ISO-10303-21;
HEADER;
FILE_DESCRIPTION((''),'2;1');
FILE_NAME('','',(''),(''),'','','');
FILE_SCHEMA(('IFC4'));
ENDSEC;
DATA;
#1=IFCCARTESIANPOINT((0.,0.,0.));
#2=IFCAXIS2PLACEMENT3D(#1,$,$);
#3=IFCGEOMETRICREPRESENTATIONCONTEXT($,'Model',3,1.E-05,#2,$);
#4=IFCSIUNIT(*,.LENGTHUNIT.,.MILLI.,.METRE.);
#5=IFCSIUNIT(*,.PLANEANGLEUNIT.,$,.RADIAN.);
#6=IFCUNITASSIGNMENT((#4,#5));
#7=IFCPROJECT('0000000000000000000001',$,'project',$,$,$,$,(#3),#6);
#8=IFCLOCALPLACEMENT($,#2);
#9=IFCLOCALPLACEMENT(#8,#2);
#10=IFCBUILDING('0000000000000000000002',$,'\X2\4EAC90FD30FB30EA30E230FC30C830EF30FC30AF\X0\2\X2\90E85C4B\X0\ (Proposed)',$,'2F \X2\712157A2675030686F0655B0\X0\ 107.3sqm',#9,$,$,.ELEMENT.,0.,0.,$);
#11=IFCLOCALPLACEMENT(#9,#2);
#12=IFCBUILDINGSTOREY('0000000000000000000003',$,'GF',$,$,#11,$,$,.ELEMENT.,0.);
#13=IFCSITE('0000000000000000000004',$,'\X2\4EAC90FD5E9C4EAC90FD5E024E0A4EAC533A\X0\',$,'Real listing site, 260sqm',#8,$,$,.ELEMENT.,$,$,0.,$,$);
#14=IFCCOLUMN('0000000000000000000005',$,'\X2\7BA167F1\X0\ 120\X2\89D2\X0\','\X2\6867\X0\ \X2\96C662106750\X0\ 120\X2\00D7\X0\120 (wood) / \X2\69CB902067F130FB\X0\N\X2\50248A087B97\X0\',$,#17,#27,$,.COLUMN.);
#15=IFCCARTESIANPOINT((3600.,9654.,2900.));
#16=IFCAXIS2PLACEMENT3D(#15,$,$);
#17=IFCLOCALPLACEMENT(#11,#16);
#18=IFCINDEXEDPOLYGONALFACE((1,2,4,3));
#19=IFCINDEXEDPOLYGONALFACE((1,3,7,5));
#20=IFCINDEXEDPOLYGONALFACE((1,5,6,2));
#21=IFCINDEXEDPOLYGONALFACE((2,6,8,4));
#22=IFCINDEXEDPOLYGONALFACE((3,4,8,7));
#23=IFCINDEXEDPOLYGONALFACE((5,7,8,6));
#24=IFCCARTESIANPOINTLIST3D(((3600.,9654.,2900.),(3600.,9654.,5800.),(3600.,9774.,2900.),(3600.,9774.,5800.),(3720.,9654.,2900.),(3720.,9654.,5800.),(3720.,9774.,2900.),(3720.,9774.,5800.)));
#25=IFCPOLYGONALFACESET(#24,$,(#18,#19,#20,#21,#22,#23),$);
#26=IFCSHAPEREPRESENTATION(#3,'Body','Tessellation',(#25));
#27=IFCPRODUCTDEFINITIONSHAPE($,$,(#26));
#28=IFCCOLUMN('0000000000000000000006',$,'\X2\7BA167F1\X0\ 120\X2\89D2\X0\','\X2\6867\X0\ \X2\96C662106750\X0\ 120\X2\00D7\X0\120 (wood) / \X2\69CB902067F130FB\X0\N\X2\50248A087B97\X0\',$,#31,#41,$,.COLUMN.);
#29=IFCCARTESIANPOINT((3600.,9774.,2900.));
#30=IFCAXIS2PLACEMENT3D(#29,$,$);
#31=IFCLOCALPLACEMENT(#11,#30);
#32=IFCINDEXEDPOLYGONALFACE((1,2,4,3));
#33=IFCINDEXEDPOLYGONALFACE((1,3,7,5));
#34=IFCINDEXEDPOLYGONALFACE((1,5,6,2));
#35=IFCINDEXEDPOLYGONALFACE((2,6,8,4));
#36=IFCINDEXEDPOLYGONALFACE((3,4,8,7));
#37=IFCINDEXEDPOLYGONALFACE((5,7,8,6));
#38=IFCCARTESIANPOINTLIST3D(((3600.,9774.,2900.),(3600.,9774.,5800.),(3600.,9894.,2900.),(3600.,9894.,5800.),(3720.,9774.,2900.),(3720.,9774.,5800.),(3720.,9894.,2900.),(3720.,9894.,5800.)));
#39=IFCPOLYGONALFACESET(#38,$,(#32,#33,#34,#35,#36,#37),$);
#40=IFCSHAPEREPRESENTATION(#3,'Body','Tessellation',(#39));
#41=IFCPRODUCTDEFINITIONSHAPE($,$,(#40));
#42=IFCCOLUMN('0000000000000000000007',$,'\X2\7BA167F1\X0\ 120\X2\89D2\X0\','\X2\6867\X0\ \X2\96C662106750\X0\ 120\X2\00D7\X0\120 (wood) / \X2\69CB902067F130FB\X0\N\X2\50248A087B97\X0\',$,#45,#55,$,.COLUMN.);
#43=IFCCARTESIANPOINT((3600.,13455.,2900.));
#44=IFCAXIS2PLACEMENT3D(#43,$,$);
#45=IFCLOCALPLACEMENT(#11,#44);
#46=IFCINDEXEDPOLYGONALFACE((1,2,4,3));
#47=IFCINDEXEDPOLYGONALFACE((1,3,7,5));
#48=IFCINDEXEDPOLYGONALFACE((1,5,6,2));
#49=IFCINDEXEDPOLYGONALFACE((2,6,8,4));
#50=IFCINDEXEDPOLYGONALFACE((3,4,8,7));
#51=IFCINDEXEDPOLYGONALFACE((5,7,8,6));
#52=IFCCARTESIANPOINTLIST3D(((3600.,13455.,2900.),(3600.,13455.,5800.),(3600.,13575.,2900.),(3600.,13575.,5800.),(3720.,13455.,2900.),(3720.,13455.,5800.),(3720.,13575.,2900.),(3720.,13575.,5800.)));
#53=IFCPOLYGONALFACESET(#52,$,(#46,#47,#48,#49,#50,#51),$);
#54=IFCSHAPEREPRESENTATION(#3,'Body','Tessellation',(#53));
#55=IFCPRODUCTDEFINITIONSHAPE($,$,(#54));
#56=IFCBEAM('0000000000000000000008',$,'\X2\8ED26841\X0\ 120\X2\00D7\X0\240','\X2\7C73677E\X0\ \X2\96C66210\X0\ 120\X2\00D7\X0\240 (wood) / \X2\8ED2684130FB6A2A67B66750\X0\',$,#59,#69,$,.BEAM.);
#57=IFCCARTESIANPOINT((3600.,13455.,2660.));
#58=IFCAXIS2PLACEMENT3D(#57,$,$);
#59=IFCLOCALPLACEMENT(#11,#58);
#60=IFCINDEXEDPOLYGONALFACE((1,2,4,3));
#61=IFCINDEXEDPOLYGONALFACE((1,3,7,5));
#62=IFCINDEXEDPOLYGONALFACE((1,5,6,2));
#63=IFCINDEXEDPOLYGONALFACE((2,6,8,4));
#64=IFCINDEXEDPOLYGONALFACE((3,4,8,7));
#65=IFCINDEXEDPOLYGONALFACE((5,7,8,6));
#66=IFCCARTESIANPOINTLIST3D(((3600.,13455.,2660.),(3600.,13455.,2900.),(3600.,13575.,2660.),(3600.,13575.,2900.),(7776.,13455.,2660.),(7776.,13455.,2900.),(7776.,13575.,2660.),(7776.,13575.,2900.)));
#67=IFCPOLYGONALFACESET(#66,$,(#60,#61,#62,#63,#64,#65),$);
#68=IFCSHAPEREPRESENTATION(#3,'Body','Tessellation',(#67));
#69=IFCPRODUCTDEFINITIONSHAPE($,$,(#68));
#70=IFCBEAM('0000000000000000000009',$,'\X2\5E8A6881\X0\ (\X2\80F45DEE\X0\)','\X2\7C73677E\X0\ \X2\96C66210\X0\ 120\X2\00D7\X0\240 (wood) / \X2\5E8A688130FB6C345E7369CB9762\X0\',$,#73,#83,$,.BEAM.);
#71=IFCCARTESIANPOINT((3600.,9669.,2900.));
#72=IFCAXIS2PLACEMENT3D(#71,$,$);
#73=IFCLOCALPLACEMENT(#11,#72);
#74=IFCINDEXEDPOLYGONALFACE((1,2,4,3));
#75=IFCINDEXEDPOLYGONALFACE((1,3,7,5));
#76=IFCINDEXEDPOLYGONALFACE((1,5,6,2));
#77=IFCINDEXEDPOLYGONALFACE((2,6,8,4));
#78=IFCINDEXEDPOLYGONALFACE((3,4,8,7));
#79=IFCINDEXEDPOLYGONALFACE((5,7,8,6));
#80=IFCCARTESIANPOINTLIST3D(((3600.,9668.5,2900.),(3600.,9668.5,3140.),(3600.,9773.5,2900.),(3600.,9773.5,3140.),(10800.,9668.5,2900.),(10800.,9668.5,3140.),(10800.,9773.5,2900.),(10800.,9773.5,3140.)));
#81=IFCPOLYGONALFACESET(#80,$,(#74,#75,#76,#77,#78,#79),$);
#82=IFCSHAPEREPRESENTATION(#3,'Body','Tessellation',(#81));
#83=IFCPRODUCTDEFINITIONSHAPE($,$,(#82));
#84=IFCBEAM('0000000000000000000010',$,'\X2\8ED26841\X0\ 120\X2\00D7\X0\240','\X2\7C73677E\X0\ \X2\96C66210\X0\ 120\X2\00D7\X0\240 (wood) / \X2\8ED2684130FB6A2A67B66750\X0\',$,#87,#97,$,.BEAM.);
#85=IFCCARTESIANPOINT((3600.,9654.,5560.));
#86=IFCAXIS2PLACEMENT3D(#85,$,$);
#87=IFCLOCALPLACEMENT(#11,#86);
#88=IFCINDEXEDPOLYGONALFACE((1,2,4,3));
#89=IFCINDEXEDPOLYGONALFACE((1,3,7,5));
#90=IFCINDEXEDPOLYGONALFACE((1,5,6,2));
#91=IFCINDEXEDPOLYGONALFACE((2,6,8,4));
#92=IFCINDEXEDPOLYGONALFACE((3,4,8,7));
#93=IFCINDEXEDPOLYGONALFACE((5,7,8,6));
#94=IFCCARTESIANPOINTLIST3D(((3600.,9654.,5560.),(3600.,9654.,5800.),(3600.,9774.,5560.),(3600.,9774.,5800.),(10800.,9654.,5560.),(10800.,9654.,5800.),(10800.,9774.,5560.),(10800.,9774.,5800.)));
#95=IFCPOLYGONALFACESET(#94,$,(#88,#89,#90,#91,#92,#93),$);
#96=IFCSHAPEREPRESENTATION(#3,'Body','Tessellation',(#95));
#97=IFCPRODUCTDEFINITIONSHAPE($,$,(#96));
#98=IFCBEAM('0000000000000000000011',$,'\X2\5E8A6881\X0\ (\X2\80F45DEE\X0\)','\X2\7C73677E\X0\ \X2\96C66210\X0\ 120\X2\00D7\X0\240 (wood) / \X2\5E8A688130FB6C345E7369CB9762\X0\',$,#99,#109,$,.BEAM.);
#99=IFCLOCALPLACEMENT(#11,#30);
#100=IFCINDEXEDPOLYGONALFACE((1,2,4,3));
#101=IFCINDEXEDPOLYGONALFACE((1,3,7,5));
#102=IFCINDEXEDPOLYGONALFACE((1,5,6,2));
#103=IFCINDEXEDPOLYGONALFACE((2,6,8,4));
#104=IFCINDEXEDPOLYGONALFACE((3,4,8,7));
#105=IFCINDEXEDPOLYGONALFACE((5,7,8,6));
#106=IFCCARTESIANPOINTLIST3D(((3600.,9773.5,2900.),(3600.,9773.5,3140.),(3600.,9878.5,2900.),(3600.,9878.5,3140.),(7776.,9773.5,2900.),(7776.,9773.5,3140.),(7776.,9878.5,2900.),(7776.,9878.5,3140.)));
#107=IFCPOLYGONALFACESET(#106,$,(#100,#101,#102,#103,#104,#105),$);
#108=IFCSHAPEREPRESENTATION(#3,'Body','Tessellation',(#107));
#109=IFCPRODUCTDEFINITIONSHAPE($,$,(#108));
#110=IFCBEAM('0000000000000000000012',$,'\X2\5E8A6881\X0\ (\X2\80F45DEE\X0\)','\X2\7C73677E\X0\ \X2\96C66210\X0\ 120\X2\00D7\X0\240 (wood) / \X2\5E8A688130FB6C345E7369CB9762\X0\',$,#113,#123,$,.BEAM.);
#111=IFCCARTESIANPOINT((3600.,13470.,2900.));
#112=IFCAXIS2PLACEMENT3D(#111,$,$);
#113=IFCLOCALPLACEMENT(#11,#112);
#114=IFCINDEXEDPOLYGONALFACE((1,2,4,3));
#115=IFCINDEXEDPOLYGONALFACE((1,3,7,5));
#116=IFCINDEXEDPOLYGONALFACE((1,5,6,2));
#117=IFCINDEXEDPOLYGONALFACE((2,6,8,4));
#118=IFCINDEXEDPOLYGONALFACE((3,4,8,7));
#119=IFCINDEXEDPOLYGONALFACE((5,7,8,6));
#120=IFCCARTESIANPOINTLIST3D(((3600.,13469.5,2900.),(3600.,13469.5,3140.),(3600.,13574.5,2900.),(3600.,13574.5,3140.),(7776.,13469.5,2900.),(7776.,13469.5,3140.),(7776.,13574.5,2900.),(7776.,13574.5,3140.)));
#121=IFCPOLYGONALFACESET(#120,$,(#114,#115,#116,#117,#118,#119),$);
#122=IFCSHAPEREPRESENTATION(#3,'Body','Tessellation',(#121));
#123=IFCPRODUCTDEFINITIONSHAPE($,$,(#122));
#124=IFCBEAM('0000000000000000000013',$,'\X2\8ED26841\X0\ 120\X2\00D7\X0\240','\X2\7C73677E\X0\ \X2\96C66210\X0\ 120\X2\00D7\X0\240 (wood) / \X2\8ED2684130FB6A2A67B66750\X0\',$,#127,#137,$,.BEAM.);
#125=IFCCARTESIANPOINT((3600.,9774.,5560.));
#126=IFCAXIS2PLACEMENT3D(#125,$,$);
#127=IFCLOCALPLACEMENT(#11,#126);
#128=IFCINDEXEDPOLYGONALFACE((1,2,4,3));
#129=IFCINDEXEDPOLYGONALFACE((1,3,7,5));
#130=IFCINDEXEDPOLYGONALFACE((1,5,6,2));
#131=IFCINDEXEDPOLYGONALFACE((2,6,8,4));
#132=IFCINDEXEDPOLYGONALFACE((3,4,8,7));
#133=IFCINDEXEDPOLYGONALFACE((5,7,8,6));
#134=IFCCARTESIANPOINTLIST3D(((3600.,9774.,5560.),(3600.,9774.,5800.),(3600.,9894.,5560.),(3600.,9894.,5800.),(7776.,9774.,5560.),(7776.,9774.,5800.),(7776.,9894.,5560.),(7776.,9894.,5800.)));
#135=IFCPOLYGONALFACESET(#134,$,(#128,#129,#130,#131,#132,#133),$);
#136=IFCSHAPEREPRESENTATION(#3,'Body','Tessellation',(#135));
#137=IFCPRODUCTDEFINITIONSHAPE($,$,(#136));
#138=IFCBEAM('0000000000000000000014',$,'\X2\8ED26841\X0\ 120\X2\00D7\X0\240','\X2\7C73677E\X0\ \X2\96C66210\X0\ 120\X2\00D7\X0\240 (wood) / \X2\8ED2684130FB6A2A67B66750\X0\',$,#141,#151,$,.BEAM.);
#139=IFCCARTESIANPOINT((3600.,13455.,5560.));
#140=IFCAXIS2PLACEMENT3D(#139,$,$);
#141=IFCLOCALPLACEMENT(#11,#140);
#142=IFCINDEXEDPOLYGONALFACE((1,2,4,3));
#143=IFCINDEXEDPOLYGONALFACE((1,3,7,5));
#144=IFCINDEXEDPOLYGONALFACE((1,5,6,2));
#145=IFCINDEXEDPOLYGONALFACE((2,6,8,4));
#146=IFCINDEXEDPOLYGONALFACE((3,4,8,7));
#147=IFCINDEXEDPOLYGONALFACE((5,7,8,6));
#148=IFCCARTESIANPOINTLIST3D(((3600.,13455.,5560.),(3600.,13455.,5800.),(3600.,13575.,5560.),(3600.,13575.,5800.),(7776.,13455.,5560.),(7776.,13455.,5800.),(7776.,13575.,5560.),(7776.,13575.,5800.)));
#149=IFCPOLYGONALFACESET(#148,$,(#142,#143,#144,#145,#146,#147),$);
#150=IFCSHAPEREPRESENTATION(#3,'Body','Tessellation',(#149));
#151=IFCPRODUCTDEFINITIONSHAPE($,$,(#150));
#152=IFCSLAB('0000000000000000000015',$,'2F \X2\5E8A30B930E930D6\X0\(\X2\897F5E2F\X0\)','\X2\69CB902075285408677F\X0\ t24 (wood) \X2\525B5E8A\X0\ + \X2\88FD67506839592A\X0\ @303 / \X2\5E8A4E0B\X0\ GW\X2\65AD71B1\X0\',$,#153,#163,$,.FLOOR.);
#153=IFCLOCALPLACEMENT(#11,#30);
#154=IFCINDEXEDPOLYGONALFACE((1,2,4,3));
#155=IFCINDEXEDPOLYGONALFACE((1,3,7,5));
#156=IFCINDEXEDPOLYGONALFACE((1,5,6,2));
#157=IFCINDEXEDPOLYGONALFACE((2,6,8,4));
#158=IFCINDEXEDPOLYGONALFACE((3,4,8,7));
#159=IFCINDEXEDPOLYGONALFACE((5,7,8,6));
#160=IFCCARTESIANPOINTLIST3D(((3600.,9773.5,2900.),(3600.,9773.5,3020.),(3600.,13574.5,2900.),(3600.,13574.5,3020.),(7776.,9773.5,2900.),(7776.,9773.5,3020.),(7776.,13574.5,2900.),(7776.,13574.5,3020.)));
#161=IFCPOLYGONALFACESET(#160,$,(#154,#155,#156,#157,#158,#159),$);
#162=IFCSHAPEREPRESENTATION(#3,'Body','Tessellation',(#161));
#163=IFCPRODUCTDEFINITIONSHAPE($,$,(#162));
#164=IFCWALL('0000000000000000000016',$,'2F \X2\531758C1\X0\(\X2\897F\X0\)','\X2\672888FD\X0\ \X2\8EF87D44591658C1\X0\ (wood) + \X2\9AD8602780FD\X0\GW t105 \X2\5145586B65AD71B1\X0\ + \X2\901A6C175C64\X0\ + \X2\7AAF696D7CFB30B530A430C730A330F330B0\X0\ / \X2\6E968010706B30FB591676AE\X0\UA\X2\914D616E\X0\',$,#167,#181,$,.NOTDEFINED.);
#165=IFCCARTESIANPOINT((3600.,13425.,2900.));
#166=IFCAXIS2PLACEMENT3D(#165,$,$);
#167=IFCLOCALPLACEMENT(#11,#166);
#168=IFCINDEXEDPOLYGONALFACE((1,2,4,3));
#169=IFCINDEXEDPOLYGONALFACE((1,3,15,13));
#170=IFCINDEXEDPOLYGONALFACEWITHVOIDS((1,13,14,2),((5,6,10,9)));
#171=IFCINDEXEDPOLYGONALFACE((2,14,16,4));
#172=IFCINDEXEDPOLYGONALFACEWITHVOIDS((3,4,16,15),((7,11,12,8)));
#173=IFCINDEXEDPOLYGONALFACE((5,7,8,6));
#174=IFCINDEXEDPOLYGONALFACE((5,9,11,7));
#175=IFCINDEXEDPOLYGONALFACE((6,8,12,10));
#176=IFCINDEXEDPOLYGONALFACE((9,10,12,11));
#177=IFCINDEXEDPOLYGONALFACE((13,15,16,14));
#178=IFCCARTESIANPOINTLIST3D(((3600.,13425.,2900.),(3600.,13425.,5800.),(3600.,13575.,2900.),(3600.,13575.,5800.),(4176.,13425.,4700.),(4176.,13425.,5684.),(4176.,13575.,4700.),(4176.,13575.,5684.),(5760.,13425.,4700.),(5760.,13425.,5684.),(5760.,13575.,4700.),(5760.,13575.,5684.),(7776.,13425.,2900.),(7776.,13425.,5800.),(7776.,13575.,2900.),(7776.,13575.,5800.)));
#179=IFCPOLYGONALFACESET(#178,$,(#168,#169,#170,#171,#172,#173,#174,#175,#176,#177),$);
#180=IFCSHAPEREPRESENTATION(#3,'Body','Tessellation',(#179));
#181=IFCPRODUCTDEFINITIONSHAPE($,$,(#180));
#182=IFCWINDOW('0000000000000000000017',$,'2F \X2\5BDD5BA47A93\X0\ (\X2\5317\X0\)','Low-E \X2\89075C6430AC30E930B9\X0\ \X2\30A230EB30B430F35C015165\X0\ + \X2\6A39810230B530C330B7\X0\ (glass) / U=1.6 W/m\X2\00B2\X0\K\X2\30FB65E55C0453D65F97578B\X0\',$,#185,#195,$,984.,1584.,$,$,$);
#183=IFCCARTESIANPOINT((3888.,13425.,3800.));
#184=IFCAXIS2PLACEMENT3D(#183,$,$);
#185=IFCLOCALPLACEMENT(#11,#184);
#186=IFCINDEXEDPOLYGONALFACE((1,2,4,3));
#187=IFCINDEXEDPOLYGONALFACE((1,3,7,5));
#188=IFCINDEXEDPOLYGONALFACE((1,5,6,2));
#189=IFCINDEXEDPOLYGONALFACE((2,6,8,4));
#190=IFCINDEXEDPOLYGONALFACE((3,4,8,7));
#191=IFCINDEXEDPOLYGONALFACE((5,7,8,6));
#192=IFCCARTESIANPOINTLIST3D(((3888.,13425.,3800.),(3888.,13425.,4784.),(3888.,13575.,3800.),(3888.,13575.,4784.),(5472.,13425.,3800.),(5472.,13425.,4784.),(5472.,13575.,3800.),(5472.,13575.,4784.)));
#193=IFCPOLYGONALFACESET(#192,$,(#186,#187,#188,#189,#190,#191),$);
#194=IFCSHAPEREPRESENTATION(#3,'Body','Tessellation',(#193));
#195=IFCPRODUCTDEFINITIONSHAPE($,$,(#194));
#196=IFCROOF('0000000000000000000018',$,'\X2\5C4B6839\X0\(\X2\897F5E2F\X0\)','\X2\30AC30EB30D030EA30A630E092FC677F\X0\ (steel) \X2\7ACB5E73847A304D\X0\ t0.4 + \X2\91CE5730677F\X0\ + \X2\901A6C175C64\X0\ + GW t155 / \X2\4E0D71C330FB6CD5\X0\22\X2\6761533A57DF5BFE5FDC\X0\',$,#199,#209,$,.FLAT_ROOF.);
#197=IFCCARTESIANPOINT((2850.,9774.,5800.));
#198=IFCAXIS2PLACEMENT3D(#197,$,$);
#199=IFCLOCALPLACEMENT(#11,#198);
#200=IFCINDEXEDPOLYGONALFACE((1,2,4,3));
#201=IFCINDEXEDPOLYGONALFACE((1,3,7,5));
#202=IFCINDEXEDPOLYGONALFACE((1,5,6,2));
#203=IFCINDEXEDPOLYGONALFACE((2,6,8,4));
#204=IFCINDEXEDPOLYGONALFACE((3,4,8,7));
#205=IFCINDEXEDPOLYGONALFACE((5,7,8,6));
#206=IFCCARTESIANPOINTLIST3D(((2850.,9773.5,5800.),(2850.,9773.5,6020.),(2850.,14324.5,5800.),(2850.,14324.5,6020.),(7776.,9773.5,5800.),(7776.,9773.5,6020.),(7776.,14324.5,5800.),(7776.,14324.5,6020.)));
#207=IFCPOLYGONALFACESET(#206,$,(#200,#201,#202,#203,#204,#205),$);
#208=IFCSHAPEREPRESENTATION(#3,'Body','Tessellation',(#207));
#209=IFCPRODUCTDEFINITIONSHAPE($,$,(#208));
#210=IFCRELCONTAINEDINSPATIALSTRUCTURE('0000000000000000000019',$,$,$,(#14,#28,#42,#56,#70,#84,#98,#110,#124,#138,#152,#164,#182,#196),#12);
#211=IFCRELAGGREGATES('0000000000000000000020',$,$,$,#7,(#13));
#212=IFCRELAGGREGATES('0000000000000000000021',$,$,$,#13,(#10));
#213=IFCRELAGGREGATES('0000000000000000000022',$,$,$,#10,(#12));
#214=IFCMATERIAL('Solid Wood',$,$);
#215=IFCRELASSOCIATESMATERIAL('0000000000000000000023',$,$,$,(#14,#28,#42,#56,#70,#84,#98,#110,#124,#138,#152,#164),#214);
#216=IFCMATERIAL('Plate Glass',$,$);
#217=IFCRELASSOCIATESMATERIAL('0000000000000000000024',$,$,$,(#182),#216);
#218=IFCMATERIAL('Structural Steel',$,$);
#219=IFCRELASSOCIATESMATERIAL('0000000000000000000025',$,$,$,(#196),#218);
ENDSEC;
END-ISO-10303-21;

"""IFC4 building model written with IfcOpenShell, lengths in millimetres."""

from ifc_helpers import new_model, si_unit, frame, frame_2d, origin, place, context, project, spatial, rectangle, extrude, material, element, fill, save


model = new_model("IFC4")

# Units and contexts
model_context = context("Model", 3, precision=1e-05, world=origin())
ifc_project = project(units=[si_unit("LENGTHUNIT", "METRE", prefix="MILLI"), si_unit("PLANEANGLEUNIT", "RADIAN")], contexts=[model_context])

# Site, building, storey
site_placement = place(None, origin())
site = spatial("IfcSite", under=ifc_project, at=site_placement, Name="京都府京都市上京区", ObjectType="Real listing site, 260sqm", CompositionType="ELEMENT", RefElevation=0.0)
building_placement = place(site_placement, origin())
building = spatial("IfcBuilding", under=site, at=building_placement, Name="京都・リモートワーク2部屋 (Proposed)", ObjectType="2F 無垢材と漆喰 107.3sqm", CompositionType="ELEMENT", ElevationOfRefHeight=0.0, ElevationOfTerrain=0.0)
storey_placement = place(building_placement, origin())
storey = spatial("IfcBuildingStorey", under=building, at=storey_placement, Name="GF", CompositionType="ELEMENT", Elevation=0.0)

# Columns
ifc_material_1 = material(Name="Solid Wood")
column_1_placement = place(storey_placement, frame((3600.0, 9654.0, 2900.0)))
element("IfcColumn", 1, at=column_1_placement, inside=storey, material=ifc_material_1, Name="管柱 120角", Description="桧 集成材 120×120 (wood) / 構造柱・N値計算", PredefinedType="COLUMN", context=model_context, shape_type="SweptSolid", body=[
    extrude(rectangle(XDim=120.0, YDim=120.0, at=frame_2d((60.0, 60.0))), frame((3600.0, 9654.0, 2900.0)), (0.0, 0.0, 1.0), 2900.0),
])
column_2_placement = place(storey_placement, frame((3600.0, 9774.0, 2900.0)))
element("IfcColumn", 2, at=column_2_placement, inside=storey, material=ifc_material_1, Name="管柱 120角", Description="桧 集成材 120×120 (wood) / 構造柱・N値計算", PredefinedType="COLUMN", context=model_context, shape_type="SweptSolid", body=[
    extrude(rectangle(XDim=120.0, YDim=120.0, at=frame_2d((60.0, 60.0))), frame((3600.0, 9774.0, 2900.0)), (0.0, 0.0, 1.0), 2900.0),
])
column_3_placement = place(storey_placement, frame((3600.0, 13455.0, 2900.0)))
element("IfcColumn", 3, at=column_3_placement, inside=storey, material=ifc_material_1, Name="管柱 120角", Description="桧 集成材 120×120 (wood) / 構造柱・N値計算", PredefinedType="COLUMN", context=model_context, shape_type="SweptSolid", body=[
    extrude(rectangle(XDim=120.0, YDim=120.0, at=frame_2d((60.0, 60.0))), frame((3600.0, 13455.0, 2900.0)), (0.0, 0.0, 1.0), 2900.0),
])

# Beams
beam_1_placement = place(storey_placement, frame((3600.0, 13455.0, 2660.0)))
element("IfcBeam", 4, at=beam_1_placement, inside=storey, material=ifc_material_1, Name="軒桁 120×240", Description="米松 集成 120×240 (wood) / 軒桁・横架材", PredefinedType="BEAM", context=model_context, shape_type="SweptSolid", body=[
    extrude(rectangle(XDim=4176.0, YDim=120.0, at=frame_2d((2088.0, 60.0))), frame((3600.0, 13455.0, 2660.0)), (0.0, 0.0, 1.0), 240.0),
])
beam_2_placement = place(storey_placement, frame((3600.0, 9669.0, 2900.0)))
element("IfcBeam", 5, at=beam_2_placement, inside=storey, material=ifc_material_1, Name="床梁 (胴差)", Description="米松 集成 120×240 (wood) / 床梁・水平構面", PredefinedType="BEAM", context=model_context, shape_type="SweptSolid", body=[
    extrude(rectangle(XDim=7200.0, YDim=105.0, at=frame_2d((3600.0, 52.0))), frame((3600.0, 9669.0, 2900.0)), (0.0, 0.0, 1.0), 240.0),
])
beam_3_placement = place(storey_placement, frame((3600.0, 9654.0, 5560.0)))
element("IfcBeam", 6, at=beam_3_placement, inside=storey, material=ifc_material_1, Name="軒桁 120×240", Description="米松 集成 120×240 (wood) / 軒桁・横架材", PredefinedType="BEAM", context=model_context, shape_type="SweptSolid", body=[
    extrude(rectangle(XDim=7200.0, YDim=120.0, at=frame_2d((3600.0, 60.0))), frame((3600.0, 9654.0, 5560.0)), (0.0, 0.0, 1.0), 240.0),
])
beam_4_placement = place(storey_placement, frame((3600.0, 9774.0, 2900.0)))
element("IfcBeam", 7, at=beam_4_placement, inside=storey, material=ifc_material_1, Name="床梁 (胴差)", Description="米松 集成 120×240 (wood) / 床梁・水平構面", PredefinedType="BEAM", context=model_context, shape_type="SweptSolid", body=[
    extrude(rectangle(XDim=4176.0, YDim=105.0, at=frame_2d((2088.0, 52.0))), frame((3600.0, 9774.0, 2900.0)), (0.0, 0.0, 1.0), 240.0),
])
beam_5_placement = place(storey_placement, frame((3600.0, 13470.0, 2900.0)))
element("IfcBeam", 8, at=beam_5_placement, inside=storey, material=ifc_material_1, Name="床梁 (胴差)", Description="米松 集成 120×240 (wood) / 床梁・水平構面", PredefinedType="BEAM", context=model_context, shape_type="SweptSolid", body=[
    extrude(rectangle(XDim=4176.0, YDim=105.0, at=frame_2d((2088.0, 52.0))), frame((3600.0, 13470.0, 2900.0)), (0.0, 0.0, 1.0), 240.0),
])
beam_6_placement = place(storey_placement, frame((3600.0, 9774.0, 5560.0)))
element("IfcBeam", 9, at=beam_6_placement, inside=storey, material=ifc_material_1, Name="軒桁 120×240", Description="米松 集成 120×240 (wood) / 軒桁・横架材", PredefinedType="BEAM", context=model_context, shape_type="SweptSolid", body=[
    extrude(rectangle(XDim=4176.0, YDim=120.0, at=frame_2d((2088.0, 60.0))), frame((3600.0, 9774.0, 5560.0)), (0.0, 0.0, 1.0), 240.0),
])
beam_7_placement = place(storey_placement, frame((3600.0, 13455.0, 5560.0)))
element("IfcBeam", 10, at=beam_7_placement, inside=storey, material=ifc_material_1, Name="軒桁 120×240", Description="米松 集成 120×240 (wood) / 軒桁・横架材", PredefinedType="BEAM", context=model_context, shape_type="SweptSolid", body=[
    extrude(rectangle(XDim=4176.0, YDim=120.0, at=frame_2d((2088.0, 60.0))), frame((3600.0, 13455.0, 5560.0)), (0.0, 0.0, 1.0), 240.0),
])

# Slab
slab_placement = place(storey_placement, frame((3600.0, 9774.0, 2900.0)))
element("IfcSlab", 11, at=slab_placement, inside=storey, material=ifc_material_1, Name="2F 床スラブ(西帯)", Description="構造用合板 t24 (wood) 剛床 + 製材根太 @303 / 床下 GW断熱", PredefinedType="FLOOR", context=model_context, shape_type="SweptSolid", body=[
    extrude(rectangle(XDim=4176.0, YDim=3801.0, at=frame_2d((2088.0, 1900.0))), frame((3600.0, 9774.0, 2900.0)), (0.0, 0.0, 1.0), 120.0),
])

# Wall, opening, window
wall_1_placement = place(storey_placement, frame((3600.0, 13425.0, 2900.0)))
wall_1 = element("IfcWall", 12, at=wall_1_placement, inside=storey, material=ifc_material_1, Name="2F 北壁(西)", Description="木製 軸組外壁 (wood) + 高性能GW t105 充填断熱 + 通気層 + 窯業系サイディング / 準耐火・外皮UA配慮", PredefinedType="NOTDEFINED", context=model_context, shape_type="SweptSolid", body=[
    extrude(rectangle(XDim=4176.0, YDim=150.0, at=frame_2d((2088.0, 75.0))), frame((3600.0, 13425.0, 2900.0)), (0.0, 0.0, 1.0), 2900.0),
])
opening_placement = place(storey_placement, frame((3888.0, 13425.0, 3800.0)))
opening = element("IfcOpeningElement", 13, at=opening_placement, cuts=wall_1, PredefinedType="NOTDEFINED", context=model_context, shape_type="SweptSolid", body=[
    extrude(rectangle(XDim=1584.0, YDim=150.0, at=frame_2d((792.0, 75.0))), frame((3888.0, 13425.0, 3800.0)), (0.0, 0.0, 1.0), 984.0),
])
ifc_material_2 = material(Name="Plate Glass")
window_placement = place(storey_placement, frame((3888.0, 13425.0, 3800.0)))
window = element("IfcWindow", 14, at=window_placement, inside=storey, material=ifc_material_2, Name="2F 寝室窓 (北)", Description="Low-E 複層ガラス アルゴン封入 + 樹脂サッシ (glass) / U=1.6 W/m²K・日射取得型", OverallHeight=984.0, OverallWidth=1584.0, context=model_context, shape_type="SweptSolid", body=[
    extrude(rectangle(XDim=1584.0, YDim=150.0, at=frame_2d((792.0, 75.0))), frame((3888.0, 13425.0, 3800.0)), (0.0, 0.0, 1.0), 984.0),
])
fill(opening, window)

# Roof
ifc_material_3 = material(Name="Structural Steel")
for number, where, name in (
    (15, (2850.0, 9774.0, 5800.0), "屋根(西帯)"),
):
    element("IfcRoof", number, at=place(storey_placement, frame(where)), inside=storey, material=ifc_material_3, Name=name, Description="ガルバリウム鋼板 (steel) 立平葺き t0.4 + 野地板 + 通気層 + GW t155 / 不燃・法22条区域対応", PredefinedType="FLAT_ROOF", context=model_context, shape_type="SweptSolid", body=[
        extrude(rectangle(XDim=4926.0, YDim=4551.0, at=frame_2d((2463.0, 2275.0))), frame((2850.0, 9774.0, 5800.0)), (0.0, 0.0, 1.0), 220.0),
    ])

save(model, "model.ifc")
